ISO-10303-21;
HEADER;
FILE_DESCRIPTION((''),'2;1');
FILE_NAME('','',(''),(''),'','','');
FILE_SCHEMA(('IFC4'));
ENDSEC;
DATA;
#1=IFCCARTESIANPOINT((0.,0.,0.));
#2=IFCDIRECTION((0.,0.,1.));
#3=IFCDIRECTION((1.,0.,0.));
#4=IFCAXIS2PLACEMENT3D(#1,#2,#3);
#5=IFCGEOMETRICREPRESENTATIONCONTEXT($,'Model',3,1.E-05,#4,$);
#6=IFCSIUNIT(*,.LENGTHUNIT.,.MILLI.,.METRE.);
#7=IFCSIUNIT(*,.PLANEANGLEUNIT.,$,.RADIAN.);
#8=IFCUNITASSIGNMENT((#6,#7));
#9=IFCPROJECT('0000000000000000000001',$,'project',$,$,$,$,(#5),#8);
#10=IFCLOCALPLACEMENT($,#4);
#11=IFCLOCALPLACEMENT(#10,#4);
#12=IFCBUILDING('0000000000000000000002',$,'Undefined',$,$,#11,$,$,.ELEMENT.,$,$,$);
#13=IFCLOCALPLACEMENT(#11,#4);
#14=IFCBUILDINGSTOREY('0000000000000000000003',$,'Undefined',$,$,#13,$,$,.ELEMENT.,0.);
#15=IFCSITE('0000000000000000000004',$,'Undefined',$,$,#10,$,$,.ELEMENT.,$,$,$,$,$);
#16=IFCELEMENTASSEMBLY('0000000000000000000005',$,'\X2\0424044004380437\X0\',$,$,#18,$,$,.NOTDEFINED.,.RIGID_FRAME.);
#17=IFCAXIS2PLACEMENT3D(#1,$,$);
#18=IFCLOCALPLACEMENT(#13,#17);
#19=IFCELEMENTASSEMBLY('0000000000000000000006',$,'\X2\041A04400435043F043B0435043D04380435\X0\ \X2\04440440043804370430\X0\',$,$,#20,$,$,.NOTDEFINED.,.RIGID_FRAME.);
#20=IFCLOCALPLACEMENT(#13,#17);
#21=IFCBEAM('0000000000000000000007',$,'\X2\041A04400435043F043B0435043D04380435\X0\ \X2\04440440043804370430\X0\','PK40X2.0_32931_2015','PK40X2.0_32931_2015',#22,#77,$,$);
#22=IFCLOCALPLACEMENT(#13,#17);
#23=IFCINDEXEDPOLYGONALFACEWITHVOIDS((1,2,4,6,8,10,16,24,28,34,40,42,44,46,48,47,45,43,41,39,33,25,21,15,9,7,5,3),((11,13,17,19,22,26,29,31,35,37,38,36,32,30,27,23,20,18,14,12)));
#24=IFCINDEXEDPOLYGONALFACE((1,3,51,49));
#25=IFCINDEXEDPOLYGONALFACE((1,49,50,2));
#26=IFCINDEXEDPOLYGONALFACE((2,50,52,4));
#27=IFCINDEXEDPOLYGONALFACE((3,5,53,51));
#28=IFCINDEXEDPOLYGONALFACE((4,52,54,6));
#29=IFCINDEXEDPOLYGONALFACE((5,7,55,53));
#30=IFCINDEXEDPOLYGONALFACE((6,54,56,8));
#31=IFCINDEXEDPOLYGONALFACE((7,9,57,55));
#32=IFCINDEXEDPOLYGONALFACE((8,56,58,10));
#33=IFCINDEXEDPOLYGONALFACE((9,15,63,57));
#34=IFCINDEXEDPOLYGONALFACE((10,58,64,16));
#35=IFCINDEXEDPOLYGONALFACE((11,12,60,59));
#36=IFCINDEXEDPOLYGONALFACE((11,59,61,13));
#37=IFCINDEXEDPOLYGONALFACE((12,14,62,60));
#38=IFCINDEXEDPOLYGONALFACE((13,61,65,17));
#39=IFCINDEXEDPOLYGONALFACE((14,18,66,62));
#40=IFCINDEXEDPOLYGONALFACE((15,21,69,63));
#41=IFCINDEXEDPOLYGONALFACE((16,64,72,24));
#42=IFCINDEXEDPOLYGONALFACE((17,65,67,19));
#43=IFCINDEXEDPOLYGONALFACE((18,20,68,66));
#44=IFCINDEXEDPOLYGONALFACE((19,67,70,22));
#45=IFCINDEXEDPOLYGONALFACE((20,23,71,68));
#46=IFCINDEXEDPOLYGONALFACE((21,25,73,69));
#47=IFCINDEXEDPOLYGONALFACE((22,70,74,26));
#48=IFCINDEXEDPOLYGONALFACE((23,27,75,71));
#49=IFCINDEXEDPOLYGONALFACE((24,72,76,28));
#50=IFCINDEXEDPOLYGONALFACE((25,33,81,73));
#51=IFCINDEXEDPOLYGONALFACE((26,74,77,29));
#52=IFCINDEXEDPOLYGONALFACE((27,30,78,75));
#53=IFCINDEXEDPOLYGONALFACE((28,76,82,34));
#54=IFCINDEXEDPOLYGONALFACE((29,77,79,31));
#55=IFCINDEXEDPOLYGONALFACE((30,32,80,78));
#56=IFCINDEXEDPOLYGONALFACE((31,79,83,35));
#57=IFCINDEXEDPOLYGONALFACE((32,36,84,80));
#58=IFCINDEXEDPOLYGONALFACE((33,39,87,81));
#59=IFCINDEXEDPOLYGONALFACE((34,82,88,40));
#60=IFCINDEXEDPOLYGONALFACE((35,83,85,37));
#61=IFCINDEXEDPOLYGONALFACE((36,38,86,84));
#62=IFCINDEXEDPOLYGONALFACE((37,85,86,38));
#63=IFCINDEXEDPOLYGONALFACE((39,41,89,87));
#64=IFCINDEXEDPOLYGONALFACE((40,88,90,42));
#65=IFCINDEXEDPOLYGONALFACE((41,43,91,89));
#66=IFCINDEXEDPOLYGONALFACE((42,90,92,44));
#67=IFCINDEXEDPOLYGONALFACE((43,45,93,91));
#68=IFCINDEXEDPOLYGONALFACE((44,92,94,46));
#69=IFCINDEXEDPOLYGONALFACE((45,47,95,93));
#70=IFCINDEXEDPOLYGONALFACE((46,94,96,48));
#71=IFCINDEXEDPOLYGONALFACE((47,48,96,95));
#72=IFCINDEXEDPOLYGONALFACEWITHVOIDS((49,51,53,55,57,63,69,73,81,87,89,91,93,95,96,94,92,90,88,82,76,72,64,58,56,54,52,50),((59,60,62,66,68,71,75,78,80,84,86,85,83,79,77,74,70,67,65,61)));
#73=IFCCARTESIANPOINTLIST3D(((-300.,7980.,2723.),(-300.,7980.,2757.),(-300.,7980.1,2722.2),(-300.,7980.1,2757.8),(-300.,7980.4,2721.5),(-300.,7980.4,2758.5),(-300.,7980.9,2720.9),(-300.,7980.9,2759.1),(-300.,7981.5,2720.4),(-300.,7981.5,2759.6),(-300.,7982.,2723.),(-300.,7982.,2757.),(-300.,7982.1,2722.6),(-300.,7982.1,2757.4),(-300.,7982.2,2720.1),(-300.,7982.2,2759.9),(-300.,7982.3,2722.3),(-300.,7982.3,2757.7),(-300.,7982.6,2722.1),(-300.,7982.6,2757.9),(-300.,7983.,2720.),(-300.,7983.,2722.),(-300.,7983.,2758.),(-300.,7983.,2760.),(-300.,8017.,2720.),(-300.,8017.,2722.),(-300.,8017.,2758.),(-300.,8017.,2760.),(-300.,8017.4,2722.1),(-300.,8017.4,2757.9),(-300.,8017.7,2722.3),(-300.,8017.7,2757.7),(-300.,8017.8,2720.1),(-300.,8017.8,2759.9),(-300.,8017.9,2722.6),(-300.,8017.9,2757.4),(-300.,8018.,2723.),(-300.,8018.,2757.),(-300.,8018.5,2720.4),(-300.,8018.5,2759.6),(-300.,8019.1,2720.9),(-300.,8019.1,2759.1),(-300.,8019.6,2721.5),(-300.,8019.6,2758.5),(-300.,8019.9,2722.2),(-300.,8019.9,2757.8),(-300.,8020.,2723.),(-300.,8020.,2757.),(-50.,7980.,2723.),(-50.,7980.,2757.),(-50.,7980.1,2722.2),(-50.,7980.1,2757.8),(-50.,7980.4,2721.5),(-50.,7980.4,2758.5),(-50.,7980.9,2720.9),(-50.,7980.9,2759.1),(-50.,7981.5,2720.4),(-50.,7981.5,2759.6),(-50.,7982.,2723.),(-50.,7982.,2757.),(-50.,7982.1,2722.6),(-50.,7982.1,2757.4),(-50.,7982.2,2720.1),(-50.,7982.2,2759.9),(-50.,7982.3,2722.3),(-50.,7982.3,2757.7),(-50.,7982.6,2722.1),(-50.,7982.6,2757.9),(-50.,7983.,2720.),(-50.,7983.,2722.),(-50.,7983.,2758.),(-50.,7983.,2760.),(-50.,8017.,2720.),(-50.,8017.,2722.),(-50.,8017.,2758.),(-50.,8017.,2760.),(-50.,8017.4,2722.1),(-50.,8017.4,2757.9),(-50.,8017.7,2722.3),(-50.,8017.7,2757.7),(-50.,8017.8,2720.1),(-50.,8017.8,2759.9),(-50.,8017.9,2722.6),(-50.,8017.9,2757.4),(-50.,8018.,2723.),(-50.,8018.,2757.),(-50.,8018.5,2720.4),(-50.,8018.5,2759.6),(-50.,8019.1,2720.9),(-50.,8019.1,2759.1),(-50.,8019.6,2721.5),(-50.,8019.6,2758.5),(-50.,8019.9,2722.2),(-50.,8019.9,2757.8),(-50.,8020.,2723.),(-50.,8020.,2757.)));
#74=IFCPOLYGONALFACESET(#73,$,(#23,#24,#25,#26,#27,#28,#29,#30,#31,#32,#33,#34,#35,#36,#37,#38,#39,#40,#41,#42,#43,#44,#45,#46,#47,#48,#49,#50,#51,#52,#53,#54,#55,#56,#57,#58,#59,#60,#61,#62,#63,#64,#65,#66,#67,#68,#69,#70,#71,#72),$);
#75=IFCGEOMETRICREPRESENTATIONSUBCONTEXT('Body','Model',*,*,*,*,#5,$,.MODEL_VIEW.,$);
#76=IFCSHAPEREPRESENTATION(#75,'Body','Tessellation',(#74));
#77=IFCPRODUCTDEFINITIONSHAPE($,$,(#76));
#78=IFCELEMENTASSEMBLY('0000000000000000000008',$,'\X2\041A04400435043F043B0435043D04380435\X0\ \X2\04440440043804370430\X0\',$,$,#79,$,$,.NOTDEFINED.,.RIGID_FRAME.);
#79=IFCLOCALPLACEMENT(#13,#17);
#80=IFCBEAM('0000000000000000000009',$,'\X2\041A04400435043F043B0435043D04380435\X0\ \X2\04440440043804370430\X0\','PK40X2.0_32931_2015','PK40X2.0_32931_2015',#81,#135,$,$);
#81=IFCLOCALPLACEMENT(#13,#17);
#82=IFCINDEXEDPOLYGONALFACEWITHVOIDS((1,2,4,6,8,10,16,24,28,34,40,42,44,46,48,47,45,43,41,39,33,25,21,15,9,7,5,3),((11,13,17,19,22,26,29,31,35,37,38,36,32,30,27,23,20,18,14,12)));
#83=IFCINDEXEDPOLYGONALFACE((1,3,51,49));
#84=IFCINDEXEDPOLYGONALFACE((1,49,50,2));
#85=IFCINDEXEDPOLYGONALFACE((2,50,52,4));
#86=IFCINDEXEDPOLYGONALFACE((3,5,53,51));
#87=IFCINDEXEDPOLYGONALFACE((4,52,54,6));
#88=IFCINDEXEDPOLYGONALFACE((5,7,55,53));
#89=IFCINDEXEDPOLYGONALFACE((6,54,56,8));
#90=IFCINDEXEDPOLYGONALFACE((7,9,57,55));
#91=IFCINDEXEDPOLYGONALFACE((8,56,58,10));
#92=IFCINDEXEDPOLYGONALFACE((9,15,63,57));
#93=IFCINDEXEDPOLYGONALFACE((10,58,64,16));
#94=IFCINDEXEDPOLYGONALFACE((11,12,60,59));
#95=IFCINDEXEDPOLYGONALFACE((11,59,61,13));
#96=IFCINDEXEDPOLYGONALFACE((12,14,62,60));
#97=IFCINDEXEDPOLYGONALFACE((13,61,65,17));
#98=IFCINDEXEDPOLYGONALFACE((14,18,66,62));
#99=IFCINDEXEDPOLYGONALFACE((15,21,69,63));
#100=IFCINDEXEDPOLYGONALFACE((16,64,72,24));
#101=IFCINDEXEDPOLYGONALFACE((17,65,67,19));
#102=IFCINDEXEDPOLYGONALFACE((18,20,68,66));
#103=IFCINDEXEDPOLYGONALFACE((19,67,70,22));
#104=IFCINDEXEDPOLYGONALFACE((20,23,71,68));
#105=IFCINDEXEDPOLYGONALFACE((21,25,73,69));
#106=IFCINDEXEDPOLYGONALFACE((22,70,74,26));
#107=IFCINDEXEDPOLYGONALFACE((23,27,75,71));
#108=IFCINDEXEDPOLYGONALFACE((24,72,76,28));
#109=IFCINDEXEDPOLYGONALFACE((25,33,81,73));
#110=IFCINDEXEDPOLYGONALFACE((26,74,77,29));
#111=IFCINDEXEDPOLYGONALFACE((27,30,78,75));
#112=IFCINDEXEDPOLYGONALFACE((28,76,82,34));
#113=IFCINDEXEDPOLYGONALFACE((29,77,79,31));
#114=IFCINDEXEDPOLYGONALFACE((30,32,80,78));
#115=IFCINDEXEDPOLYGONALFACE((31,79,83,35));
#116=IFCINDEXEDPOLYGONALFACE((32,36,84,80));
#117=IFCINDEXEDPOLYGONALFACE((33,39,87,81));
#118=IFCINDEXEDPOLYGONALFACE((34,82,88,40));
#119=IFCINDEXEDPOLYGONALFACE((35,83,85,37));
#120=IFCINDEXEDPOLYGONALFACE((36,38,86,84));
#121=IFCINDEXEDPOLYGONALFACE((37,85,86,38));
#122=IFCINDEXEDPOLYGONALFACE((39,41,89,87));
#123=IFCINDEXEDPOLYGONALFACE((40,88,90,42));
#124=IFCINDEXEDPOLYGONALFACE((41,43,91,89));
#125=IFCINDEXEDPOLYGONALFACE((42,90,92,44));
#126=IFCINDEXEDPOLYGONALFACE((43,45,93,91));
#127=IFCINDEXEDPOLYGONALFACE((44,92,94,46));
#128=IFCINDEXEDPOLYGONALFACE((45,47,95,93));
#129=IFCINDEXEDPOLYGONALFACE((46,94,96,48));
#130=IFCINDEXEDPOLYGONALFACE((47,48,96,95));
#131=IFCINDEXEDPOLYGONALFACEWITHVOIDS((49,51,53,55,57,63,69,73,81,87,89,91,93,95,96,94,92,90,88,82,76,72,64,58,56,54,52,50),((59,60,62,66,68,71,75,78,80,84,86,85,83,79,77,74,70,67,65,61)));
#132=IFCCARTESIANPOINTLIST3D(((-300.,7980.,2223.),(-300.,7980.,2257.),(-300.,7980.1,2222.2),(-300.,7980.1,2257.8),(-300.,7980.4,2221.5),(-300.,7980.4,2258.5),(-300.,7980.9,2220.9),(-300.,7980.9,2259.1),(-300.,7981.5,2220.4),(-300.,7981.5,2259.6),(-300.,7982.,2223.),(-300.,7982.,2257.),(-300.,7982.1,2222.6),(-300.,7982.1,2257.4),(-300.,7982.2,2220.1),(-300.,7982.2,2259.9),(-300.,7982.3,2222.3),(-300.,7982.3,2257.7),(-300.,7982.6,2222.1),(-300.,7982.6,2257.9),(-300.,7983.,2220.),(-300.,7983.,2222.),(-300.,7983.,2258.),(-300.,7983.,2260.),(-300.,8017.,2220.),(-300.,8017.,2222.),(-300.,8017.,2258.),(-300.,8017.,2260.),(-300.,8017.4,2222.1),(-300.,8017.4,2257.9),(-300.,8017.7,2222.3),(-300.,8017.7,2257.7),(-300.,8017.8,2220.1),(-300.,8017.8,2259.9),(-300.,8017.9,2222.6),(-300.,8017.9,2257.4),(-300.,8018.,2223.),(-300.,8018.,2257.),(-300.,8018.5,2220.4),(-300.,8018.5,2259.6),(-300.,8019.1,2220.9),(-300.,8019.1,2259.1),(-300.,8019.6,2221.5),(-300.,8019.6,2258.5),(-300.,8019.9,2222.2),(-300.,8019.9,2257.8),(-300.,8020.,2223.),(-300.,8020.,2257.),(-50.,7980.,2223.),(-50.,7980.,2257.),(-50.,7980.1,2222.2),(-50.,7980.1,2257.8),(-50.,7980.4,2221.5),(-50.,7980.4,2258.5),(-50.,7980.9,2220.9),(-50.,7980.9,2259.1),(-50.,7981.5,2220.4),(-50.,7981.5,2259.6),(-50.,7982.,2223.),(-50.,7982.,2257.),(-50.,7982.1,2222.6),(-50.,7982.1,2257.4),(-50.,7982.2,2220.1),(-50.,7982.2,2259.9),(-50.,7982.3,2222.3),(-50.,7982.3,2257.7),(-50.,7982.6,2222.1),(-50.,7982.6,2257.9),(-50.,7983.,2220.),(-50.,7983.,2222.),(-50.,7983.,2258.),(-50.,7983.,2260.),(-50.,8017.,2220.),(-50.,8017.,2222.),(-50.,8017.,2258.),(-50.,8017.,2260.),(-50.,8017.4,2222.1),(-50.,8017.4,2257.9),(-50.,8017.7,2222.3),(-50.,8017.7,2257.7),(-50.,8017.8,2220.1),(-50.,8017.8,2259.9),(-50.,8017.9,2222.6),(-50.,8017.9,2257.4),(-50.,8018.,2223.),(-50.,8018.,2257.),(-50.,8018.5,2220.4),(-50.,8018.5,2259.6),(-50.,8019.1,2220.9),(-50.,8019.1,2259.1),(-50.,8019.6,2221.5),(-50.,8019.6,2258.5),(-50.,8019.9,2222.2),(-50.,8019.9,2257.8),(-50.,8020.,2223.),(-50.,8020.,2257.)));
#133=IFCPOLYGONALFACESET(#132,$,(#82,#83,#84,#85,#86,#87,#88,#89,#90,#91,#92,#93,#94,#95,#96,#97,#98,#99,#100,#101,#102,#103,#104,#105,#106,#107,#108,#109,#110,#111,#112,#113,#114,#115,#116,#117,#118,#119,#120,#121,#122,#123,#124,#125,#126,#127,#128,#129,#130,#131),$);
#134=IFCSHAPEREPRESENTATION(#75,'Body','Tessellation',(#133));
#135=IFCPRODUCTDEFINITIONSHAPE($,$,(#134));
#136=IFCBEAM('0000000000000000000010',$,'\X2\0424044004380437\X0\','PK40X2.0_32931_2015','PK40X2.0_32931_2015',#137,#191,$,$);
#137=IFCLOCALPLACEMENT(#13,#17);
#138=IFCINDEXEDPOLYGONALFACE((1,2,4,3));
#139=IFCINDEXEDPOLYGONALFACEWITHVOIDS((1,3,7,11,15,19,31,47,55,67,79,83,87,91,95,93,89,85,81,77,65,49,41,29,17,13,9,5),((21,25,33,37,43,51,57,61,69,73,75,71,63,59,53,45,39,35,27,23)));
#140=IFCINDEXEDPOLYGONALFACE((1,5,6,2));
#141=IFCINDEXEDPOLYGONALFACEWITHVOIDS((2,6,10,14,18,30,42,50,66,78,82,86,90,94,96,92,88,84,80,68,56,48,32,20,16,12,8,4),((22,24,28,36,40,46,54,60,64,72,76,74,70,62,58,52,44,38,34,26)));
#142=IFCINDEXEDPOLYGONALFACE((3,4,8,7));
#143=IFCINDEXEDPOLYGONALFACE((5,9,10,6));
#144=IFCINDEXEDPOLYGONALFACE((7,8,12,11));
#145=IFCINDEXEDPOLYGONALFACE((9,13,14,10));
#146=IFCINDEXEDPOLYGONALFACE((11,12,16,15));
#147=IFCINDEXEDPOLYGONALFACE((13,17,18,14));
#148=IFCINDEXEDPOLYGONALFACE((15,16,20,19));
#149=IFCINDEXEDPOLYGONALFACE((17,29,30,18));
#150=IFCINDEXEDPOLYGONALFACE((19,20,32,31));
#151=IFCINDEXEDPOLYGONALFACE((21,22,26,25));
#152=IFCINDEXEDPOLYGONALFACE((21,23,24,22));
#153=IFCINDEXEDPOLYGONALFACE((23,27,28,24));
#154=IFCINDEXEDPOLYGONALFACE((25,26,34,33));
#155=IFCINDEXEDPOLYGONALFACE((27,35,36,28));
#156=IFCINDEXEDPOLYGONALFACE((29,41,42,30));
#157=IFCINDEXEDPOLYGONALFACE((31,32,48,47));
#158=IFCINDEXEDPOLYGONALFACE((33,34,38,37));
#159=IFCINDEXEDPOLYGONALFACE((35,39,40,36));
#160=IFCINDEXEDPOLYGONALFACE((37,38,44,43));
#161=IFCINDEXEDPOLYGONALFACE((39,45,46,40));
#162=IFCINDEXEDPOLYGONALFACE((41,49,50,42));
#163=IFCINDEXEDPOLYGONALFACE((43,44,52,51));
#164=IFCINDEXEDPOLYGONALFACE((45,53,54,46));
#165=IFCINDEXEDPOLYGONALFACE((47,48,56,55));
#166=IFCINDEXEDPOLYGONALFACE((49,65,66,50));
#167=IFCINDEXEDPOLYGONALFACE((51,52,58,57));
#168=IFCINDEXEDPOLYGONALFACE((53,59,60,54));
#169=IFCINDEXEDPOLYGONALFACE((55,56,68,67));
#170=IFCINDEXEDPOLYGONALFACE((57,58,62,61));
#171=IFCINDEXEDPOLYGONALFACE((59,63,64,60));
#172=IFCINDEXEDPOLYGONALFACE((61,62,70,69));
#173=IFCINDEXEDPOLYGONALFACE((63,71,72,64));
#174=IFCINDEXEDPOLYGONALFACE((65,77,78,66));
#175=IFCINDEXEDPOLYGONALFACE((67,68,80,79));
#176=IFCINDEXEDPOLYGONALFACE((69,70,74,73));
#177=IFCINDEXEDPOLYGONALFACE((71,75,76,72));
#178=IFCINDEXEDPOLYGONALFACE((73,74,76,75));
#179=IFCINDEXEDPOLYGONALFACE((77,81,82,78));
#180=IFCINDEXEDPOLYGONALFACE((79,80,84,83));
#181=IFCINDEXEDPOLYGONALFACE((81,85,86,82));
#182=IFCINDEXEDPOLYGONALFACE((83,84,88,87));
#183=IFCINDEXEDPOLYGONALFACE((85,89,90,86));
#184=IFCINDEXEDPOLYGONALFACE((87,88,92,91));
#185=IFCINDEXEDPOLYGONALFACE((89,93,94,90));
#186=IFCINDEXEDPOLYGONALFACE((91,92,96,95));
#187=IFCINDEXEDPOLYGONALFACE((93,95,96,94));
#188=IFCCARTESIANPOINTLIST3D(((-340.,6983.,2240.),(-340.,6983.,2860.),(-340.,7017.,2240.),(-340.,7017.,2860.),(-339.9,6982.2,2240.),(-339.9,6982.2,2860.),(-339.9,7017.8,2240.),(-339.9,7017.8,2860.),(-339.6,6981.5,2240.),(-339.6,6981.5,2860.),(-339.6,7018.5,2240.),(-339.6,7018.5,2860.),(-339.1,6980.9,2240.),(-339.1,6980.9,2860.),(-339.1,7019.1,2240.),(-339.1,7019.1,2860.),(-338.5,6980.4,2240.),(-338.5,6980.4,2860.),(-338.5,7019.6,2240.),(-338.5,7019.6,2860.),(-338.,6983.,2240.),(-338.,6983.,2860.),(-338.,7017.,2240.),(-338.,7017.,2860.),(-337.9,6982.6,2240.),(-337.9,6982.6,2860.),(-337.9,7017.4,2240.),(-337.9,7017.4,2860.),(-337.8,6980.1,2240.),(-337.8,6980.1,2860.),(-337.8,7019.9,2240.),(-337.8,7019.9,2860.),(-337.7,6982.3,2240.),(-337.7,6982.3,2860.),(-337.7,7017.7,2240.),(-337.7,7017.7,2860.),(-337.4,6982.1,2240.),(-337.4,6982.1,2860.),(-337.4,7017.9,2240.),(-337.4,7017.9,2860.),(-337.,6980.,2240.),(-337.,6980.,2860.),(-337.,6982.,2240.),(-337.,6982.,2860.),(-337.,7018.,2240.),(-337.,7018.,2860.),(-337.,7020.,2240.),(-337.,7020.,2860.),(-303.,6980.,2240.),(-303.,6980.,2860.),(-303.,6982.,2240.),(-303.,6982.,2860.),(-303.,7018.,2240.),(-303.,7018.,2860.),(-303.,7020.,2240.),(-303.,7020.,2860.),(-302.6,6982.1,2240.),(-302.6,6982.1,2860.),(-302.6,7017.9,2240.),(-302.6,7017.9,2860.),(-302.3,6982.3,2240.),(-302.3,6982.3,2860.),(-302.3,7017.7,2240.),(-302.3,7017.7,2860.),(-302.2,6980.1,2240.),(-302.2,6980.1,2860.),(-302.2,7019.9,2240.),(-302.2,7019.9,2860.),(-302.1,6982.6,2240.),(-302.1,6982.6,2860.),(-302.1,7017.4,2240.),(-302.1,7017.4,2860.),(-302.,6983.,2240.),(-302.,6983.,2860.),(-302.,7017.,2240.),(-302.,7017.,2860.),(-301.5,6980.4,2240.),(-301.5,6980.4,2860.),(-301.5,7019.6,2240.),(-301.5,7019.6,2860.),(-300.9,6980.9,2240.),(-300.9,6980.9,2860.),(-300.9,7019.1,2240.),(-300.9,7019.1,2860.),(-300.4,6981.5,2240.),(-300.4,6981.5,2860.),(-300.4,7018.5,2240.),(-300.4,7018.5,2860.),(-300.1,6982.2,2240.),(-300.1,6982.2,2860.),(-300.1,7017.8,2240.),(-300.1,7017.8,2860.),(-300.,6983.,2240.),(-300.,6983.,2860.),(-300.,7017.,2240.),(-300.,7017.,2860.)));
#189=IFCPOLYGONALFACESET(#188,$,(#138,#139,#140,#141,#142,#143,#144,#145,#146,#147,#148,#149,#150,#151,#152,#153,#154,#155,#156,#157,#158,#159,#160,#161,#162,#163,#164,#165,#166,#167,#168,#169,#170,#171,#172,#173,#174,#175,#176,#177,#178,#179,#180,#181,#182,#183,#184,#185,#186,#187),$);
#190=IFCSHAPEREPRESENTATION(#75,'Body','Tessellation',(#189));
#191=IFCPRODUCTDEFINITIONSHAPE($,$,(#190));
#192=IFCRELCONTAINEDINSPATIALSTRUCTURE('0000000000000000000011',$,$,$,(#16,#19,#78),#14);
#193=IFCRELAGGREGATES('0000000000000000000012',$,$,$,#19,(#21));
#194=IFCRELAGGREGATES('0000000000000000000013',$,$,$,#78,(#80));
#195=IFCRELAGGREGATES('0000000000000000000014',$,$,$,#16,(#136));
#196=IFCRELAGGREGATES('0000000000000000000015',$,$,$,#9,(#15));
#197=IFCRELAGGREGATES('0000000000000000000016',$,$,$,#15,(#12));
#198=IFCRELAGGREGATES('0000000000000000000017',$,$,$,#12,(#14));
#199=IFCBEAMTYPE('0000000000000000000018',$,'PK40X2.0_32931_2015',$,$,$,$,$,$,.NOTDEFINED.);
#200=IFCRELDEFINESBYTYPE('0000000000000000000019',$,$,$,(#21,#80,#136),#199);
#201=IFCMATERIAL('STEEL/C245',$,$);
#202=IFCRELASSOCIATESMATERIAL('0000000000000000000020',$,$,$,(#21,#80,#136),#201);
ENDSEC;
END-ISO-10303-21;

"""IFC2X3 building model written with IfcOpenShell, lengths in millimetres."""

from ifc_helpers import new_model, si_unit, frame, origin_with_axes, origin_2d_with_axis, place, context, subcontext, project, spatial, hollow_rectangle, extrude, material, type_object, element, aggregate, save


model = new_model("IFC2X3")

# Units and contexts
model_context = context("Model", 3, precision=1e-05, world=origin_with_axes())
body_context = subcontext(model_context, "Body", "Model", "MODEL_VIEW")
ifc_project = project(units=[si_unit("LENGTHUNIT", "METRE", prefix="MILLI"), si_unit("PLANEANGLEUNIT", "RADIAN")], contexts=[model_context])

# Site, building, storey
site_placement = place(None, origin_with_axes())
site = spatial("IfcSite", under=ifc_project, at=site_placement, Name="Undefined", CompositionType="ELEMENT")
building_placement = place(site_placement, origin_with_axes())
building = spatial("IfcBuilding", under=site, at=building_placement, Name="Undefined", CompositionType="ELEMENT")
storey_placement = place(building_placement, origin_with_axes())
storey = spatial("IfcBuildingStorey", under=building, at=storey_placement, Name="Undefined", CompositionType="ELEMENT", Elevation=0.0)

# Shared definitions
ifc_material_1 = material(Name="STEEL/C245")

# Element assembly
assembly_1_placement = place(storey_placement, origin_with_axes())
assembly_1 = element("IfcElementAssembly", 1, at=assembly_1_placement, inside=storey, Name="Фриз", AssemblyPlace="NOTDEFINED", PredefinedType="RIGID_FRAME")

# Element assemblies, beams
assembly_2_placement = place(storey_placement, origin_with_axes())
assembly_2 = element("IfcElementAssembly", 2, at=assembly_2_placement, inside=storey, Name="Крепление фриза", AssemblyPlace="NOTDEFINED", PredefinedType="RIGID_FRAME")
beam_type_1 = type_object("IfcBeamType", Name="PK40X2.0_32931_2015", PredefinedType="NOTDEFINED")
beam_1_placement = place(assembly_2_placement, frame((-300.0, 8000.0, 2740.0), z_axis=(0.0, 0.0, -1.0), x_axis=(1.0, 0.0, 0.0)))
beam_1 = element("IfcBeam", 3, at=beam_1_placement, type_object=beam_type_1, material=ifc_material_1, Name="Крепление фриза", Description="PK40X2.0_32931_2015", ObjectType="PK40X2.0_32931_2015", context=body_context, shape_type="SweptSolid", body=[
    extrude(hollow_rectangle(XDim=40.0, YDim=40.0, WallThickness=2.0, InnerFilletRadius=1.0, OuterFilletRadius=3.0, at=origin_2d_with_axis()), frame((250.0, 0.0, 0.0), z_axis=(-1.0, 0.0, 0.0), x_axis=(0.0, -1.0, 0.0)), (0.0, 0.0, 1.0), 250.0),
])
aggregate(assembly_2, [beam_1])
assembly_3_placement = place(storey_placement, origin_with_axes())
assembly_3 = element("IfcElementAssembly", 4, at=assembly_3_placement, inside=storey, Name="Крепление фриза", AssemblyPlace="NOTDEFINED", PredefinedType="RIGID_FRAME")
beam_2_placement = place(assembly_3_placement, frame((-300.0, 8000.0, 2240.0), z_axis=(0.0, 0.0, -1.0), x_axis=(1.0, 0.0, 0.0)))
beam_2 = element("IfcBeam", 5, at=beam_2_placement, type_object=beam_type_1, material=ifc_material_1, Name="Крепление фриза", Description="PK40X2.0_32931_2015", ObjectType="PK40X2.0_32931_2015", context=body_context, shape_type="SweptSolid", body=[
    extrude(hollow_rectangle(XDim=40.0, YDim=40.0, WallThickness=2.0, InnerFilletRadius=1.0, OuterFilletRadius=3.0, at=origin_2d_with_axis()), frame((250.0, 0.0, 0.0), z_axis=(-1.0, 0.0, 0.0), x_axis=(0.0, -1.0, 0.0)), (0.0, 0.0, 1.0), 250.0),
])
aggregate(assembly_3, [beam_2])

# Beam
beam_3_placement = place(assembly_1_placement, frame((-320.0, 7000.0, 2860.0), z_axis=(1.0, 0.0, 0.0), x_axis=(0.0, 0.0, -1.0)))
beam_3 = element("IfcBeam", 6, at=beam_3_placement, type_object=beam_type_1, material=ifc_material_1, Name="Фриз", Description="PK40X2.0_32931_2015", ObjectType="PK40X2.0_32931_2015", context=body_context, shape_type="SweptSolid", body=[
    extrude(hollow_rectangle(XDim=40.0, YDim=40.0, WallThickness=2.0, InnerFilletRadius=1.0, OuterFilletRadius=3.0, at=origin_2d_with_axis()), frame((620.0, 0.0, 0.0), z_axis=(-1.0, 0.0, 0.0), x_axis=(0.0, -1.0, 0.0)), (0.0, 0.0, 1.0), 620.0),
])
aggregate(assembly_1, [beam_3])

save(model, "model.ifc")
